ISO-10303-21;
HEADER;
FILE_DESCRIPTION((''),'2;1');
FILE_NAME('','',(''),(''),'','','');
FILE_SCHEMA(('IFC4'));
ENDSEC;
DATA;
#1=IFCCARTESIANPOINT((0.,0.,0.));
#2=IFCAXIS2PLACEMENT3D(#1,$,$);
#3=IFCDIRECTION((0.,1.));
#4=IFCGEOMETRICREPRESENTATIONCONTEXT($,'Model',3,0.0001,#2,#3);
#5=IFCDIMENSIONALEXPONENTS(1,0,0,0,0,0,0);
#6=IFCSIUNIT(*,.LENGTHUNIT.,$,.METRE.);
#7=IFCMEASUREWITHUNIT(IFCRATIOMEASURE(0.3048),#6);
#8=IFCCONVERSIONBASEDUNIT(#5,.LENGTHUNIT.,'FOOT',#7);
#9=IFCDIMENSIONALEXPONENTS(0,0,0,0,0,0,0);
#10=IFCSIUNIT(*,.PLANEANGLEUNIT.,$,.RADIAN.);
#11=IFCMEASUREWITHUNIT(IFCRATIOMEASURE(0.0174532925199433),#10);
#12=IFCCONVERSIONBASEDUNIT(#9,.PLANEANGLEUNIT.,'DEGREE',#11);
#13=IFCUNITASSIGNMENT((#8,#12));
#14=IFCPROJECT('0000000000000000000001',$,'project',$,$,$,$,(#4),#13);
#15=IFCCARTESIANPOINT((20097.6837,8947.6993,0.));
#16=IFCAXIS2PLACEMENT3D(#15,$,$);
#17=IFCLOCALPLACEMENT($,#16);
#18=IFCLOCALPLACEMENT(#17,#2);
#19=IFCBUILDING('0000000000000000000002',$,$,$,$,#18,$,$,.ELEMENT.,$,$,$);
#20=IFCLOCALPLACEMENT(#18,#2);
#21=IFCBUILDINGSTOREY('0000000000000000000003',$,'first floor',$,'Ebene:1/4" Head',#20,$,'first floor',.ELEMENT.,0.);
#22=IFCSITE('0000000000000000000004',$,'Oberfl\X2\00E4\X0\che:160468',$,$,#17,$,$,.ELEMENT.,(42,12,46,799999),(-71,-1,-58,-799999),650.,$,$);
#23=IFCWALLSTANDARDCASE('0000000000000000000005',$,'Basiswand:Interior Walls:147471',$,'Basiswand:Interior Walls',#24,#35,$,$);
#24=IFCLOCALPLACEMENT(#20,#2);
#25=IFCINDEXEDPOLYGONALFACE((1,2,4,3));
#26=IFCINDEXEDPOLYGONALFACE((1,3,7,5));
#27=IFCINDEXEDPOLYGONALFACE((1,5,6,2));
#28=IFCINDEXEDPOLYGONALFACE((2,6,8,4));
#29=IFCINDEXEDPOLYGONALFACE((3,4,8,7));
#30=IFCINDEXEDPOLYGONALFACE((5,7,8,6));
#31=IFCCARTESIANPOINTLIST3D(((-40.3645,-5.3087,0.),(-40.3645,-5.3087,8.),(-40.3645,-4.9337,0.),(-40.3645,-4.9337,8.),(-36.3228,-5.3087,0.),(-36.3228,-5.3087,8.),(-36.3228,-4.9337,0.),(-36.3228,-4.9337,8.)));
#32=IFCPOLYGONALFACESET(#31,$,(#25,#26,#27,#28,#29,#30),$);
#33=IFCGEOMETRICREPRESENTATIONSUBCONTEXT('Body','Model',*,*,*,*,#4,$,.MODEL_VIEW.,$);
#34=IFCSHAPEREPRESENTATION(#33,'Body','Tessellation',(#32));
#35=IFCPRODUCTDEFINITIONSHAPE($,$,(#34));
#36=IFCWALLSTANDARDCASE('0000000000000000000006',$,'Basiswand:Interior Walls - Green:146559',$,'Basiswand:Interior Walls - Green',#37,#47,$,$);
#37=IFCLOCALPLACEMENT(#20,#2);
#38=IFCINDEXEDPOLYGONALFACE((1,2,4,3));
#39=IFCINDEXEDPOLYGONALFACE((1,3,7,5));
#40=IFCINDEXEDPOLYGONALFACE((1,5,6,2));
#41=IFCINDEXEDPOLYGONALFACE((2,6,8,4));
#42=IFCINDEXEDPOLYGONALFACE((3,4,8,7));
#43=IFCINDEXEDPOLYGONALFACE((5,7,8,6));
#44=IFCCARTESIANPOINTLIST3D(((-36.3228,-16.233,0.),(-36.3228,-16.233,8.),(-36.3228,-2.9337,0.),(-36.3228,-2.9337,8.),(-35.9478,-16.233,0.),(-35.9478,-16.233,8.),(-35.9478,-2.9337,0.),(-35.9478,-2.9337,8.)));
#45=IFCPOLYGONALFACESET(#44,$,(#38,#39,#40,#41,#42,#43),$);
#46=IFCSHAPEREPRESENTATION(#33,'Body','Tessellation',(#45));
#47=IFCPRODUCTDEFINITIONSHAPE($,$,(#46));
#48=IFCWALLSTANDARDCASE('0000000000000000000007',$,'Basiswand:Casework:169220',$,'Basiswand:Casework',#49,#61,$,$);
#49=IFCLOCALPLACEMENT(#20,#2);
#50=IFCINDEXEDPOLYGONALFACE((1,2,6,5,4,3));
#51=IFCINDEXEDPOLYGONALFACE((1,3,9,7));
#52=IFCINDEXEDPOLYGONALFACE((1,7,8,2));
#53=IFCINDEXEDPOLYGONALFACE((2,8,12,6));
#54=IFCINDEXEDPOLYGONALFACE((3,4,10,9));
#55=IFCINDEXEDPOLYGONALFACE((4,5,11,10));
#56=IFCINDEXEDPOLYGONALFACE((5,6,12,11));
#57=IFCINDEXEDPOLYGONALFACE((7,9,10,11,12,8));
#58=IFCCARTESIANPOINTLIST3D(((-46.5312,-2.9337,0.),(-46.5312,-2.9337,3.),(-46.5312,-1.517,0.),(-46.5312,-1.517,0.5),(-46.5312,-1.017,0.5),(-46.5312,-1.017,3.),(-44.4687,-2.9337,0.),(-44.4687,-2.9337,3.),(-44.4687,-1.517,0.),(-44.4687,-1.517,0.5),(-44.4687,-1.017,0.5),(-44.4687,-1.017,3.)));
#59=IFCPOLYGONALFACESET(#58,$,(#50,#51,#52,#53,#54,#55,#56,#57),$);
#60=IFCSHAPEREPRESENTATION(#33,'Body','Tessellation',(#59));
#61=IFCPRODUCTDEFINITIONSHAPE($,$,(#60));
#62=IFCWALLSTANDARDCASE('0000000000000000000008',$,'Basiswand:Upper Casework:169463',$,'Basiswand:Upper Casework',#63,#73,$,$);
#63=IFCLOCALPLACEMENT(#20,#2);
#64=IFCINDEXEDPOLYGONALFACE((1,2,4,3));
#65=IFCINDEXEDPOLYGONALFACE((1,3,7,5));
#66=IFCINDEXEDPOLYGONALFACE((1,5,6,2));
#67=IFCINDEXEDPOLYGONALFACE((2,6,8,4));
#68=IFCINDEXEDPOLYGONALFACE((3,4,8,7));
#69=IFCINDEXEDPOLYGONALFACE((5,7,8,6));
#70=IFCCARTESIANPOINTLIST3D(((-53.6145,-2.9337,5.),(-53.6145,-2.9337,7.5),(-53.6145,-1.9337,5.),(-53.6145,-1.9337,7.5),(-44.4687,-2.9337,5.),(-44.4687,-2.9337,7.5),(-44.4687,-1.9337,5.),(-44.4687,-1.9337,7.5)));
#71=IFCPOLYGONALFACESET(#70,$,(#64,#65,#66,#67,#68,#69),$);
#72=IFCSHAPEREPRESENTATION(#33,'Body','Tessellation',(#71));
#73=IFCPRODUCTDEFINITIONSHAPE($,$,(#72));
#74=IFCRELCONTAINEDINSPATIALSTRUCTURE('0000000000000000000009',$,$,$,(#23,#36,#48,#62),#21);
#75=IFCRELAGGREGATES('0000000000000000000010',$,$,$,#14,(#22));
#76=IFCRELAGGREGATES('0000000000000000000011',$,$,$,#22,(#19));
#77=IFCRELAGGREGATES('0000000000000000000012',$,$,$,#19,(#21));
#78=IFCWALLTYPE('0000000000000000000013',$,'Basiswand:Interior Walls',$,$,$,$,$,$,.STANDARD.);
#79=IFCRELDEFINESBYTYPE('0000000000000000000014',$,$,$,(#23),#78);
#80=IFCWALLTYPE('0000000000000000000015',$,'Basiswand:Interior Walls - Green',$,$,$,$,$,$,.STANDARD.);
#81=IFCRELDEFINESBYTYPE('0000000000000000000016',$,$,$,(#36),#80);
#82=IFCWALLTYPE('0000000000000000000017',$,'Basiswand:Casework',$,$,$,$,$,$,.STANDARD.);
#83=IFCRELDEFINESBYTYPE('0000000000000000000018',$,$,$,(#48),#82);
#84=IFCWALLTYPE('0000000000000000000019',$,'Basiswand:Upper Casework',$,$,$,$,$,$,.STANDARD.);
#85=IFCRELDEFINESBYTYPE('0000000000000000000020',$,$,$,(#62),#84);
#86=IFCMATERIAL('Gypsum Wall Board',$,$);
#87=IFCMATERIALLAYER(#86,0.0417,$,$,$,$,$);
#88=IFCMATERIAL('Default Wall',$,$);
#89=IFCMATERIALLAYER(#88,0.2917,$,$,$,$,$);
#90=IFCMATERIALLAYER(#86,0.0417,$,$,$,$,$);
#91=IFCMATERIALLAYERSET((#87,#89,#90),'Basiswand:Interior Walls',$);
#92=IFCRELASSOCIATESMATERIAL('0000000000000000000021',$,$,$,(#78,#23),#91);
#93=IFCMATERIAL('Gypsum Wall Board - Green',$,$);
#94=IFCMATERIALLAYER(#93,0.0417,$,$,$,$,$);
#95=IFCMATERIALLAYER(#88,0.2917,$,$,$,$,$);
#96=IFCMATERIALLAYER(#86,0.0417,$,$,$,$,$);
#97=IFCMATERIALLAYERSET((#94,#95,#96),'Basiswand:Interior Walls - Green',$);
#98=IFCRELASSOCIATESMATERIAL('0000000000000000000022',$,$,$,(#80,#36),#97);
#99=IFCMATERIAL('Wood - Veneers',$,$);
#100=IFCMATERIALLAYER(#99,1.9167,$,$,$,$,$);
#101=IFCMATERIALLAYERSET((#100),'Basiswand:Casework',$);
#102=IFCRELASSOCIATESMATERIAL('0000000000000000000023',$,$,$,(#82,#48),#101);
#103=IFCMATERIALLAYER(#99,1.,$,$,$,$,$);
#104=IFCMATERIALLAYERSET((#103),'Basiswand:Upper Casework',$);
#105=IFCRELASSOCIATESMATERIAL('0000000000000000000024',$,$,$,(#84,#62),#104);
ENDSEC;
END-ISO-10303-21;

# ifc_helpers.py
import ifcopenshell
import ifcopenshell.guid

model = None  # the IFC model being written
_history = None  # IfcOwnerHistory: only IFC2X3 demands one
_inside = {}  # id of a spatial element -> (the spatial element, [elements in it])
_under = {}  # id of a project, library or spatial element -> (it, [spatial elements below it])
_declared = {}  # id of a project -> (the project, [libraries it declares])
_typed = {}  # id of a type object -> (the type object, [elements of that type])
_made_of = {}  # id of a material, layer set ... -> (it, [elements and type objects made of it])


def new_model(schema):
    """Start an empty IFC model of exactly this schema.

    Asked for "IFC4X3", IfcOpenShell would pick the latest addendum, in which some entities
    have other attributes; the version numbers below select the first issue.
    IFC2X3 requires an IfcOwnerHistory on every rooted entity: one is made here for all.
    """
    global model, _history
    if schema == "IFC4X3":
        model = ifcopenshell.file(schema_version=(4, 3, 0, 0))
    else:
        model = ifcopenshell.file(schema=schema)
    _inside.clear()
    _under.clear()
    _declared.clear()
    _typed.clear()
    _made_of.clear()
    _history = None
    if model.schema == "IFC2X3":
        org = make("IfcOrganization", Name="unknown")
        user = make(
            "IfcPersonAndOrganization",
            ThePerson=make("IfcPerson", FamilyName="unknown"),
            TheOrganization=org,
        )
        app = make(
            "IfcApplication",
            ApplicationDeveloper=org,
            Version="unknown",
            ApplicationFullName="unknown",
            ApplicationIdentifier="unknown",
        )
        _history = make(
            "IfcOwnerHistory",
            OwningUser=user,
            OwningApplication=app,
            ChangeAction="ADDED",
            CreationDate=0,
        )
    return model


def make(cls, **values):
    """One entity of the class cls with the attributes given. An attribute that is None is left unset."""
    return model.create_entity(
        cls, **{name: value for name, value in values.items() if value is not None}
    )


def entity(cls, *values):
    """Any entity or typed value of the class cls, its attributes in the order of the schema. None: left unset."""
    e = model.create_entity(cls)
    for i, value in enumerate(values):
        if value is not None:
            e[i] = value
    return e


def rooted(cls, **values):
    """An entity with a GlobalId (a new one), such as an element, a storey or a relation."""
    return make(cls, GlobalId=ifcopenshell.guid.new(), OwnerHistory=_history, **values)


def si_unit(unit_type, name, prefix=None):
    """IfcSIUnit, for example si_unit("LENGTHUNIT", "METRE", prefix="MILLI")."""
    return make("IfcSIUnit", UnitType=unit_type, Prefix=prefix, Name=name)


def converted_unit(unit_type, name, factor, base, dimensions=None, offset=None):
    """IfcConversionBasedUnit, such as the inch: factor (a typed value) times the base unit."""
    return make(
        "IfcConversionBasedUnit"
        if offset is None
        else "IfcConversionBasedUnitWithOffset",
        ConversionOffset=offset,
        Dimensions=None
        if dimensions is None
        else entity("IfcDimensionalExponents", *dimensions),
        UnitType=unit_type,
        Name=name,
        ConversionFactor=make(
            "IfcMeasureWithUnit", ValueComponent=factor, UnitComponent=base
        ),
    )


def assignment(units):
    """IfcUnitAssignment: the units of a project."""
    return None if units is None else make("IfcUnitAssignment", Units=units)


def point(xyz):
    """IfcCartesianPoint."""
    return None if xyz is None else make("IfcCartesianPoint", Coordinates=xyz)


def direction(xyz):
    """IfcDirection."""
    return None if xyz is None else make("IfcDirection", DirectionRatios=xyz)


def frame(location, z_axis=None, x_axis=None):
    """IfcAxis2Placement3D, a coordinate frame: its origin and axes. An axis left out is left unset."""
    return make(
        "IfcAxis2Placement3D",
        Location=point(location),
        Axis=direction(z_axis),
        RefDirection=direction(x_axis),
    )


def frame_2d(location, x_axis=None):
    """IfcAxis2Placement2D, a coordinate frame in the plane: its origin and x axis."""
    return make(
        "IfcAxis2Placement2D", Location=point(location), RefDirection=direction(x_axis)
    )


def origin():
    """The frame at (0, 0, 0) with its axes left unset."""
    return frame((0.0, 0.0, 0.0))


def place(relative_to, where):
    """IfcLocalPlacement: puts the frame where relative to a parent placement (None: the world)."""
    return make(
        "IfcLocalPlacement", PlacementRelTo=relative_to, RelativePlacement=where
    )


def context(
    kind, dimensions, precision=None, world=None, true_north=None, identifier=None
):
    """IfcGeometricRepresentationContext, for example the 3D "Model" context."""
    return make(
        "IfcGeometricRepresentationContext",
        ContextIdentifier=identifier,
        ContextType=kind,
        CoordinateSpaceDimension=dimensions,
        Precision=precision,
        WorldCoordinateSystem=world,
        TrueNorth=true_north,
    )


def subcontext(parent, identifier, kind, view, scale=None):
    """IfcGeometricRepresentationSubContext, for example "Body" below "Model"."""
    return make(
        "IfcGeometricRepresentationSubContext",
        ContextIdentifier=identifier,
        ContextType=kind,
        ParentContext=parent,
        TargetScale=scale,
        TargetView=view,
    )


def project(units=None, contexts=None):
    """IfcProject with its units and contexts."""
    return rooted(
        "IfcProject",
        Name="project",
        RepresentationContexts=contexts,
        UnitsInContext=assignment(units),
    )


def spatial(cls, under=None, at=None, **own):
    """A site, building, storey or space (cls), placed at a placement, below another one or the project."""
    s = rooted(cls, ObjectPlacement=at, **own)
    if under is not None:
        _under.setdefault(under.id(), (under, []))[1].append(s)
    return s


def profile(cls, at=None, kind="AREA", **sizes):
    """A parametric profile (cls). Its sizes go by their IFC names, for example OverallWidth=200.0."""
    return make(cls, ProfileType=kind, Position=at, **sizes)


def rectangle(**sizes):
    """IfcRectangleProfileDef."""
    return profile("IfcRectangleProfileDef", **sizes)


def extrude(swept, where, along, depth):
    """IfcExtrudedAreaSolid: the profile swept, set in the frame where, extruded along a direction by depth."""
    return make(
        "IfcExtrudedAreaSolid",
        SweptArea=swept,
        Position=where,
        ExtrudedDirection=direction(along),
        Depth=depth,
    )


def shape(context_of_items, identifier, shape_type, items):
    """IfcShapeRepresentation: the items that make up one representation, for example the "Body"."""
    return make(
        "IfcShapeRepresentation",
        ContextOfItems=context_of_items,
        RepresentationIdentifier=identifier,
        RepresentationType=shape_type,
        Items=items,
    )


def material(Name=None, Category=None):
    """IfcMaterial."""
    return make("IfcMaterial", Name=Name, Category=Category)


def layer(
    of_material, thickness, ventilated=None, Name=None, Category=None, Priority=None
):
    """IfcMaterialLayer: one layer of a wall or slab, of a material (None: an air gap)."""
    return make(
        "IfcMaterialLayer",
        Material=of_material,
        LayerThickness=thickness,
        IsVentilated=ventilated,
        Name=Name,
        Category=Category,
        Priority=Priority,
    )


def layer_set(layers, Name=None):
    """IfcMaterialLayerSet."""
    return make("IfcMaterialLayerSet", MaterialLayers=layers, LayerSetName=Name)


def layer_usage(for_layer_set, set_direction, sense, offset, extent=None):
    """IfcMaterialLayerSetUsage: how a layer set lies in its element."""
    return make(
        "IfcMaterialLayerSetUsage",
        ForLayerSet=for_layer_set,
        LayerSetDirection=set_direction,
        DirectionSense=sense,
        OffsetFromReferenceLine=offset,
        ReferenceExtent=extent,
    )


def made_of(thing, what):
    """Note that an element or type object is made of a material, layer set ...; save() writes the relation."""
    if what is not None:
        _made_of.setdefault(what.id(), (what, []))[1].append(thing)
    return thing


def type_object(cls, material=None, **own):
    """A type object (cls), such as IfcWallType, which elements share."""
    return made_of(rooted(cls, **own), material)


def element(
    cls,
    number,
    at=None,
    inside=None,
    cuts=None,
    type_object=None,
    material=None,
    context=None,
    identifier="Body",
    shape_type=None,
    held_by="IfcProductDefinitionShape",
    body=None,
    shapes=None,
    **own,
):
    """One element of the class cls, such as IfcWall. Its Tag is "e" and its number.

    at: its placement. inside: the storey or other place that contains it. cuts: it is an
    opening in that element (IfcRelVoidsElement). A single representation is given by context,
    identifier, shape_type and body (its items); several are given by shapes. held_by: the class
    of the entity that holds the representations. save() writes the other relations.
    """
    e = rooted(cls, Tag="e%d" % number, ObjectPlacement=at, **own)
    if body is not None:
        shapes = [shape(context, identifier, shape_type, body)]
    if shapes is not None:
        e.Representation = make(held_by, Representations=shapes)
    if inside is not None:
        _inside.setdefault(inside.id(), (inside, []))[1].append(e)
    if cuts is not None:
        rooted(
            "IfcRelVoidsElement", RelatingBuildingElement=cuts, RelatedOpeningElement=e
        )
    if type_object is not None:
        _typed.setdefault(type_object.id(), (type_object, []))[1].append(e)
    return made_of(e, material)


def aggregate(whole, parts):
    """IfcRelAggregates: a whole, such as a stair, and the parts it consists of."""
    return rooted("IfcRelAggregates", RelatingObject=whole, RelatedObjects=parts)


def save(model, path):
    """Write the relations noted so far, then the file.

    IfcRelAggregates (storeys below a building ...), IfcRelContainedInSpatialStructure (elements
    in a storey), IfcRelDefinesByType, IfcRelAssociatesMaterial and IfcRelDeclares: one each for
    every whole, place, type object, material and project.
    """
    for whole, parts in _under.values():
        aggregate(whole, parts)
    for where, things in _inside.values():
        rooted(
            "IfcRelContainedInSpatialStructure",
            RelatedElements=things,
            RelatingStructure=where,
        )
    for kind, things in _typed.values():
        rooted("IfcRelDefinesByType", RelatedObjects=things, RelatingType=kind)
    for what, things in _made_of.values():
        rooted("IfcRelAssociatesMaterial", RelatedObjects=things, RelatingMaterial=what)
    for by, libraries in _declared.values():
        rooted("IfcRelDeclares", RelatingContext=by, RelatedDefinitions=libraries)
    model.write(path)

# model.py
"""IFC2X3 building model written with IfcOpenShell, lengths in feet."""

from ifc_helpers import new_model, entity, si_unit, converted_unit, direction, frame, frame_2d, origin, place, context, subcontext, project, spatial, rectangle, extrude, material, layer, layer_set, layer_usage, type_object, element, save


model = new_model("IFC2X3")

# Units and contexts
model_context = context("Model", 3, precision=0.0001, world=origin(), true_north=direction((0.0, 1.0)))
body_context = subcontext(model_context, "Body", "Model", "MODEL_VIEW")
ifc_project = project(units=[converted_unit("LENGTHUNIT", "FOOT", entity("IfcRatioMeasure", 0.3048), si_unit("LENGTHUNIT", "METRE"), dimensions=[1, 0, 0, 0, 0, 0, 0]), converted_unit("PLANEANGLEUNIT", "DEGREE", entity("IfcRatioMeasure", 0.0174532925199433), si_unit("PLANEANGLEUNIT", "RADIAN"), dimensions=[0, 0, 0, 0, 0, 0, 0])], contexts=[model_context])

# Site, building, storey
site_placement = place(None, frame((20097.6837, 8947.6993, 0.0)))
site = spatial("IfcSite", under=ifc_project, at=site_placement, Name="Oberfläche:160468", CompositionType="ELEMENT", RefLatitude=(42, 12, 46, 799999), RefLongitude=(-71, -1, -58, -799999), RefElevation=650.0)
building_placement = place(site_placement, origin())
building = spatial("IfcBuilding", under=site, at=building_placement, CompositionType="ELEMENT")
storey_placement = place(building_placement, origin())
storey = spatial("IfcBuildingStorey", under=building, at=storey_placement, Name="first floor", ObjectType="Ebene:1/4\" Head", LongName="first floor", CompositionType="ELEMENT", Elevation=0.0)

# Shared definitions
ifc_material_1 = material(Name="Gypsum Wall Board")

# Shared definitions
ifc_layer_1 = layer(ifc_material_1, 0.0417)
ifc_material_2 = material(Name="Default Wall")
ifc_layer_2 = layer(ifc_material_2, 0.2917)
ifc_layer_3 = layer(ifc_material_1, 0.0417)
ifc_layer_set_1 = layer_set([ifc_layer_1, ifc_layer_2, ifc_layer_3], Name="Basiswand:Interior Walls")
wall_type_1 = type_object("IfcWallType", Name="Basiswand:Interior Walls", PredefinedType="STANDARD", material=ifc_layer_set_1)

# Walls
ifc_layer_usage_1 = layer_usage(ifc_layer_set_1, "AXIS2", "NEGATIVE", 0.1875)
wall_1_placement = place(storey_placement, frame((-40.3645, -5.1212, 0.0)))
element("IfcWallStandardCase", 1, at=wall_1_placement, inside=storey, type_object=wall_type_1, material=ifc_layer_usage_1, Name="Basiswand:Interior Walls:147471", ObjectType="Basiswand:Interior Walls", context=body_context, shape_type="SweptSolid", body=[
    extrude(rectangle(XDim=4.0417, YDim=0.375, at=frame_2d((2.0208, 0.0), x_axis=(-1.0, 0.0))), origin(), (0.0, 0.0, 1.0), 8.0),
])
ifc_material_3 = material(Name="Gypsum Wall Board - Green")
ifc_layer_4 = layer(ifc_material_3, 0.0417)
ifc_layer_5 = layer(ifc_material_2, 0.2917)
ifc_layer_6 = layer(ifc_material_1, 0.0417)
ifc_layer_set_2 = layer_set([ifc_layer_4, ifc_layer_5, ifc_layer_6], Name="Basiswand:Interior Walls - Green")
ifc_layer_usage_2 = layer_usage(ifc_layer_set_2, "AXIS2", "NEGATIVE", 0.1875)
wall_type_2 = type_object("IfcWallType", Name="Basiswand:Interior Walls - Green", PredefinedType="STANDARD", material=ifc_layer_set_2)
wall_2_placement = place(storey_placement, frame((-36.1353, -2.9337, 0.0), z_axis=(0.0, 0.0, 1.0), x_axis=(0.0, -1.0, 0.0)))
element("IfcWallStandardCase", 2, at=wall_2_placement, inside=storey, type_object=wall_type_2, material=ifc_layer_usage_2, Name="Basiswand:Interior Walls - Green:146559", ObjectType="Basiswand:Interior Walls - Green", context=body_context, shape_type="SweptSolid", body=[
    extrude(rectangle(XDim=13.2993, YDim=0.375, at=frame_2d((6.6496, 0.0), x_axis=(-1.0, 0.0))), origin(), (0.0, 0.0, 1.0), 8.0),
])

# Wall, opening
ifc_material_4 = material(Name="Wood - Veneers")
ifc_layer_7 = layer(ifc_material_4, 1.9167)
ifc_layer_set_3 = layer_set([ifc_layer_7], Name="Basiswand:Casework")
ifc_layer_usage_3 = layer_usage(ifc_layer_set_3, "AXIS2", "NEGATIVE", 0.9583)
wall_type_3 = type_object("IfcWallType", Name="Basiswand:Casework", PredefinedType="STANDARD", material=ifc_layer_set_3)
wall_3_placement = place(storey_placement, frame((-44.4687, -1.9754, 0.0), z_axis=(0.0, 0.0, 1.0), x_axis=(-1.0, 0.0, 0.0)))
wall_3 = element("IfcWallStandardCase", 3, at=wall_3_placement, inside=storey, type_object=wall_type_3, material=ifc_layer_usage_3, Name="Basiswand:Casework:169220", ObjectType="Basiswand:Casework", context=body_context, shape_type="SweptSolid", body=[
    extrude(rectangle(XDim=2.0625, YDim=1.9167, at=frame_2d((1.0312, 0.0), x_axis=(-1.0, 0.0))), origin(), (0.0, 0.0, 1.0), 3.0),
])
opening_1_placement = place(wall_3_placement, origin())
element("IfcOpeningElement", 4, at=opening_1_placement, cuts=wall_3, ObjectType="Recess", context=body_context, shape_type="SweptSolid", body=[
    extrude(rectangle(XDim=0.5, YDim=2.0625, at=frame_2d((0.0, 0.0), x_axis=(0.0, 1.0))), frame((1.0312, -0.9583, 0.25), z_axis=(0.0, 1.0, 0.0), x_axis=(1.0, 0.0, 0.0)), (0.0, 0.0, 1.0), 0.5),
])

# Wall
ifc_layer_8 = layer(ifc_material_4, 1.0)
ifc_layer_set_4 = layer_set([ifc_layer_8], Name="Basiswand:Upper Casework")
ifc_layer_usage_4 = layer_usage(ifc_layer_set_4, "AXIS2", "POSITIVE", -0.5)
wall_type_4 = type_object("IfcWallType", Name="Basiswand:Upper Casework", PredefinedType="STANDARD", material=ifc_layer_set_4)
wall_4_placement = place(storey_placement, frame((-44.4687, -2.4337, 5.0), z_axis=(0.0, 0.0, 1.0), x_axis=(-1.0, 0.0, 0.0)))
element("IfcWallStandardCase", 5, at=wall_4_placement, inside=storey, type_object=wall_type_4, material=ifc_layer_usage_4, Name="Basiswand:Upper Casework:169463", ObjectType="Basiswand:Upper Casework", context=body_context, shape_type="SweptSolid", body=[
    extrude(rectangle(XDim=9.1458, YDim=1.0, at=frame_2d((4.5729, 0.0), x_axis=(-1.0, 0.0))), origin(), (0.0, 0.0, 1.0), 2.5),
])

save(model, "model.ifc")
